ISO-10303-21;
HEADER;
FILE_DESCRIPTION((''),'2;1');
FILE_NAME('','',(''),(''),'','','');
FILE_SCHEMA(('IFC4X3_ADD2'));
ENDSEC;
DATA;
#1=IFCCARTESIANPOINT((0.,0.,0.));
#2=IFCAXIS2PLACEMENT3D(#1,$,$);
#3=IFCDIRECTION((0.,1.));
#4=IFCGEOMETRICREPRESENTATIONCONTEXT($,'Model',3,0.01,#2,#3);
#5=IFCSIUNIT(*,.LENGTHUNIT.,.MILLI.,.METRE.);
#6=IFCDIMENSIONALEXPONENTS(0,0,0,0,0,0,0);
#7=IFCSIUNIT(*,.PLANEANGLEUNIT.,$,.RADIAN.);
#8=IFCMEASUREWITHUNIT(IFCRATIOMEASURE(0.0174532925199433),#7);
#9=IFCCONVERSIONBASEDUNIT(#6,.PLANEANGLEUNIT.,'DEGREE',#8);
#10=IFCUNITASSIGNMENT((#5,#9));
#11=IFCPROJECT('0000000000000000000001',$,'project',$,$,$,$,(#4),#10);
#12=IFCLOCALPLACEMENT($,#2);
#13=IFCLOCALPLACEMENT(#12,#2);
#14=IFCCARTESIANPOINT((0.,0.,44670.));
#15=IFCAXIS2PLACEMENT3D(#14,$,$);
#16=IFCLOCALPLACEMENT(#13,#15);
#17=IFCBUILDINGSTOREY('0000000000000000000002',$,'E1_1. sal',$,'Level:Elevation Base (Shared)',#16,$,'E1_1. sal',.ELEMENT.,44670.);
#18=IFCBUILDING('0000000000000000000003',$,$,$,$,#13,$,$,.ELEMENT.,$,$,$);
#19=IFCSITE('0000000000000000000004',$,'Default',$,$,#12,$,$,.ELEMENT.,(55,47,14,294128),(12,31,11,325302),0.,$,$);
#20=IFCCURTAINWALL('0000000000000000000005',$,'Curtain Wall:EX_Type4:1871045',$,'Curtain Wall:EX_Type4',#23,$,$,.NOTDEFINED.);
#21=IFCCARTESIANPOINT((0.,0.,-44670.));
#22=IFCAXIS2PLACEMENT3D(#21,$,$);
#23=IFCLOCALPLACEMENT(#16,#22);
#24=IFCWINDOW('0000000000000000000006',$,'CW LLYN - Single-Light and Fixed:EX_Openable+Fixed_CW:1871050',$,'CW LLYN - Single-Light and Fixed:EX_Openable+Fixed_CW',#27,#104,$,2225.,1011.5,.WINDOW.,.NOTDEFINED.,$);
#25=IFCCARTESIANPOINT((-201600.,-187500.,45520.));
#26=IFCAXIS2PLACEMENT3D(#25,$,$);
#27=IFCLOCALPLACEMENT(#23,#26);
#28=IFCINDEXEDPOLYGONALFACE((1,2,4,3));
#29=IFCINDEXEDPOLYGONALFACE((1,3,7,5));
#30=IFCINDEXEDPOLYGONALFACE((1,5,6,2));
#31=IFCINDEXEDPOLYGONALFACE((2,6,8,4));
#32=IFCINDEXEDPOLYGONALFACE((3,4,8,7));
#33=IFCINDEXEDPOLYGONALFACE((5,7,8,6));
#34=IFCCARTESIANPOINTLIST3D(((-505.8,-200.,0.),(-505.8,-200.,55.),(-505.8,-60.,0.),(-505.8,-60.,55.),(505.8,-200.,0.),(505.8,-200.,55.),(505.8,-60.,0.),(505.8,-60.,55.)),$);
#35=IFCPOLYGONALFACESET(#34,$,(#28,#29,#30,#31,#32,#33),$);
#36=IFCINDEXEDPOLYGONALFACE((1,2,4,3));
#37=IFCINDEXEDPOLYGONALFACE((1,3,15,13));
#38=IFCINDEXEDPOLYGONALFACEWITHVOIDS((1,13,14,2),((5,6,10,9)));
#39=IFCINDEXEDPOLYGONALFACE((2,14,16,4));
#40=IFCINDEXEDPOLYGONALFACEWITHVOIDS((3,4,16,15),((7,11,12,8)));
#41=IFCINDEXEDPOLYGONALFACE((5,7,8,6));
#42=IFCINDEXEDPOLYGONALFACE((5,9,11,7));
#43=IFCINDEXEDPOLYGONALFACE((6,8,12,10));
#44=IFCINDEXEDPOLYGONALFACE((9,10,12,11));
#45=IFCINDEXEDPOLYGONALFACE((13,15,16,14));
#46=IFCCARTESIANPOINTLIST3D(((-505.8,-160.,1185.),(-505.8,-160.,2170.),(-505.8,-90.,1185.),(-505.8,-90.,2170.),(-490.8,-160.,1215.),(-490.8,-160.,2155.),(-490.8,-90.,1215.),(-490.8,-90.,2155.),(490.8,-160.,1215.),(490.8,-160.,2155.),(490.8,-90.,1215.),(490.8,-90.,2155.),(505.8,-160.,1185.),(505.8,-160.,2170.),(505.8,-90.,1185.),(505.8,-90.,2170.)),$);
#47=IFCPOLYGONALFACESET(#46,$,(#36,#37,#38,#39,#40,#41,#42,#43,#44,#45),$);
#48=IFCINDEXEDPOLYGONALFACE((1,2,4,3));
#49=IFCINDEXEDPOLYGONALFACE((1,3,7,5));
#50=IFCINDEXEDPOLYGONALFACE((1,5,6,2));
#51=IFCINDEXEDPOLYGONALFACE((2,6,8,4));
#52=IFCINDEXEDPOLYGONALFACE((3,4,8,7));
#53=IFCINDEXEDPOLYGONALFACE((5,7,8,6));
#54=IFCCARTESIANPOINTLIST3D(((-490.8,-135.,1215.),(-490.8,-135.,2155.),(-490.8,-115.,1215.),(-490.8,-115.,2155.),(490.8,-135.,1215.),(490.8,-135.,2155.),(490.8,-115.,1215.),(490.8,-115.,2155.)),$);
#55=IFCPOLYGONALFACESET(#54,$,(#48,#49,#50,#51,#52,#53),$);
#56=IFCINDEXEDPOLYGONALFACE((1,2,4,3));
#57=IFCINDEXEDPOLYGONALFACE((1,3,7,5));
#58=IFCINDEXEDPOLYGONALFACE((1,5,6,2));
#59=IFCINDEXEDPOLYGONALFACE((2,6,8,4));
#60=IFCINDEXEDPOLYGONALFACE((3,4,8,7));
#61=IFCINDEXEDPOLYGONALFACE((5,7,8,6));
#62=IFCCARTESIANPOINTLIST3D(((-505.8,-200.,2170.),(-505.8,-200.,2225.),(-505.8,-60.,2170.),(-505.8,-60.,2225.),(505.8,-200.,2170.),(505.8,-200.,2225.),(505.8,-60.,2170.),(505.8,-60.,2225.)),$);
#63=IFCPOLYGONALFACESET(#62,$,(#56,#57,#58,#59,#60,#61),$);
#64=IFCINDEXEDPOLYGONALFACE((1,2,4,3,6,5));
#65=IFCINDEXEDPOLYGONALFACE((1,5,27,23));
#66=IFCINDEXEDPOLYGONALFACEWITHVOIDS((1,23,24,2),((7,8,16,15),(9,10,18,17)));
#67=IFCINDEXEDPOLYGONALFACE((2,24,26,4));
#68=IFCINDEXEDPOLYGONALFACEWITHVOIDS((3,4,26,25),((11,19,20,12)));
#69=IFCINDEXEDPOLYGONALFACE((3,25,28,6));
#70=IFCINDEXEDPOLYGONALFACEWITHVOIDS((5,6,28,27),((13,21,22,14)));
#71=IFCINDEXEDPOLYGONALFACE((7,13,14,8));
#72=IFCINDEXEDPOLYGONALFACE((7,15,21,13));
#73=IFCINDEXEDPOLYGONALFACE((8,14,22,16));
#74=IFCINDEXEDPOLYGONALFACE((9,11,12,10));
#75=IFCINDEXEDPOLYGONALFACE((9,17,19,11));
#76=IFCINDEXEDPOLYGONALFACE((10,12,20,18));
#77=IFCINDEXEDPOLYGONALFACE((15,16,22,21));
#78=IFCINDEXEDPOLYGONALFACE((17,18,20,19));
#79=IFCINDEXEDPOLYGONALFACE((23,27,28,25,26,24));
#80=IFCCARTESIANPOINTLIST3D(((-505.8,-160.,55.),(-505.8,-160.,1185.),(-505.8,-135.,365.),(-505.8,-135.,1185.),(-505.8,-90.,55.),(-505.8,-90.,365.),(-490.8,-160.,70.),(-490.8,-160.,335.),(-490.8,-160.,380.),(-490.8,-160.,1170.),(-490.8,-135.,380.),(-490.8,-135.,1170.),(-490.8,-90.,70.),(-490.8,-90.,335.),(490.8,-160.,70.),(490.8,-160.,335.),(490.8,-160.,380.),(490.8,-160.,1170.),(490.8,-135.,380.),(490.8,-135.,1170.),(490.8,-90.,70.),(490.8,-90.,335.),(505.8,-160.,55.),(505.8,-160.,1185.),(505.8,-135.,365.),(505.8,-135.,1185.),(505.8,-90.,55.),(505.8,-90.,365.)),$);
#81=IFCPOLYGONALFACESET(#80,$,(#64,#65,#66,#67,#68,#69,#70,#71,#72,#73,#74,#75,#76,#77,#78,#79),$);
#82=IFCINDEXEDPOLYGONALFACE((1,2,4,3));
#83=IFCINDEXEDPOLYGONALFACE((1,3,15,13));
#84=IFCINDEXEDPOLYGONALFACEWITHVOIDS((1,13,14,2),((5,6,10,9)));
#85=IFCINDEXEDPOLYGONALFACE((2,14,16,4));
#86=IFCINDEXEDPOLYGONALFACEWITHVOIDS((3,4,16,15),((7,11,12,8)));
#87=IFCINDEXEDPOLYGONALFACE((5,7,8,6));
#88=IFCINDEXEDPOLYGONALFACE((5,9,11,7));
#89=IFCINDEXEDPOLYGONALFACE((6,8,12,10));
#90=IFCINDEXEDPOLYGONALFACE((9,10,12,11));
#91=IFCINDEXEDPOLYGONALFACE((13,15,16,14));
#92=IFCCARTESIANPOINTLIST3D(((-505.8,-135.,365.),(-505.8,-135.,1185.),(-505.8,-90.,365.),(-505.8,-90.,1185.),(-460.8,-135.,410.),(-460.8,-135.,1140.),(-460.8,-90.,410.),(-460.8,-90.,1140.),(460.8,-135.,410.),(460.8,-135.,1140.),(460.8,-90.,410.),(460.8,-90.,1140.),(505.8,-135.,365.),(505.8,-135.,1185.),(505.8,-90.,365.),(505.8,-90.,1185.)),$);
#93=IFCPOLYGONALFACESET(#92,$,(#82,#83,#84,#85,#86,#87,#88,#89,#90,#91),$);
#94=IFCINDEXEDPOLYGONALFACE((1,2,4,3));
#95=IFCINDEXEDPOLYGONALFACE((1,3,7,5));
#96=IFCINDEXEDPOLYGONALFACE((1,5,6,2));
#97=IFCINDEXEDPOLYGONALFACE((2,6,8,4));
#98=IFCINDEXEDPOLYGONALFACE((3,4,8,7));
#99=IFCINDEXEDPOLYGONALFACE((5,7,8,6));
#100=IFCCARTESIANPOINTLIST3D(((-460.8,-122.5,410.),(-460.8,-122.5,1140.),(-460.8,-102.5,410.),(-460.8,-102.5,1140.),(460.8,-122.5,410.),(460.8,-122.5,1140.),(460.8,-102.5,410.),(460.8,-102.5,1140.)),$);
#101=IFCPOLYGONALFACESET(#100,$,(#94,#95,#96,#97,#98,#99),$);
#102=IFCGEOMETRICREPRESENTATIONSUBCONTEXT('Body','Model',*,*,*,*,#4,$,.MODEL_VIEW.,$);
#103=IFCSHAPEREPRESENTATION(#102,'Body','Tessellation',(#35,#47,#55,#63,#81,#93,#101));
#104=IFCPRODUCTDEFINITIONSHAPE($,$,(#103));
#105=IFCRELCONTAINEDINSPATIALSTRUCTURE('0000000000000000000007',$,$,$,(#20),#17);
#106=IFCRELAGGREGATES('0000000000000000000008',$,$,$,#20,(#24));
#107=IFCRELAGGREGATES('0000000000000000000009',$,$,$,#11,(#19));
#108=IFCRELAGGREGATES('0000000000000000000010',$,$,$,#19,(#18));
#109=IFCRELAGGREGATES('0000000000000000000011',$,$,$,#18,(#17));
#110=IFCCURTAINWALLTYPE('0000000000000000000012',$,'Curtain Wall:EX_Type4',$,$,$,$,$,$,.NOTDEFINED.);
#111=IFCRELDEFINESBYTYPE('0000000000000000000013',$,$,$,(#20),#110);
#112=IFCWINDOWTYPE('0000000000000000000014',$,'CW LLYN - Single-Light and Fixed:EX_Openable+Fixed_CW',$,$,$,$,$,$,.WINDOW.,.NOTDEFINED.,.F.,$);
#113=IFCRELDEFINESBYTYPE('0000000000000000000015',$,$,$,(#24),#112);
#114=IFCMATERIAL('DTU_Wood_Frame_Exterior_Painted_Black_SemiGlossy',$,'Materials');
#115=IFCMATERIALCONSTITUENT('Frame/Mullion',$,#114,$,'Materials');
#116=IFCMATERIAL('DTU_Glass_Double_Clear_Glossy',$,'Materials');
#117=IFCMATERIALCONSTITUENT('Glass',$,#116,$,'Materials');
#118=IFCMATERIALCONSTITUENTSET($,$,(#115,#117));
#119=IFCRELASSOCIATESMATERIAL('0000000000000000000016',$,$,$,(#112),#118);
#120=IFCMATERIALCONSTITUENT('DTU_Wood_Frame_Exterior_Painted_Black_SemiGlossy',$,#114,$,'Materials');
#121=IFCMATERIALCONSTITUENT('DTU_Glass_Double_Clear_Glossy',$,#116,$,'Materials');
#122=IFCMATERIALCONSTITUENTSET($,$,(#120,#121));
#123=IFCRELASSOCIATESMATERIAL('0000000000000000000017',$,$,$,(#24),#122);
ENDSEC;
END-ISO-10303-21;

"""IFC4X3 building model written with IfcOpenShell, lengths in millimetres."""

from ifc_helpers import new_model, entity, si_unit, converted_unit, direction, frame, frame_2d, origin, origin_2d_with_axis, place, context, subcontext, project, spatial, polyline, rectangle, outline, extrude, source, transform, mapped, material, constituent, constituent_set, type_object, type_shapes, element, aggregate, save


model = new_model("IFC4X3")

# Units and contexts
model_context = context("Model", 3, precision=0.01, world=origin(), true_north=direction((0.0, 1.0)))
body_context = subcontext(model_context, "Body", "Model", "MODEL_VIEW")
ifc_project = project(units=[si_unit("LENGTHUNIT", "METRE", prefix="MILLI"), converted_unit("PLANEANGLEUNIT", "DEGREE", entity("IfcRatioMeasure", 0.0174532925199433), si_unit("PLANEANGLEUNIT", "RADIAN"), dimensions=[0, 0, 0, 0, 0, 0, 0])], contexts=[model_context])

# Site, building, storey
site_placement = place(None, origin())
site = spatial("IfcSite", under=ifc_project, at=site_placement, Name="Default", CompositionType="ELEMENT", RefLatitude=(55, 47, 14, 294128), RefLongitude=(12, 31, 11, 325302), RefElevation=0.0)
building_placement = place(site_placement, origin())
building = spatial("IfcBuilding", under=site, at=building_placement, CompositionType="ELEMENT")
storey_placement = place(building_placement, frame((0.0, 0.0, 44670.0)))
storey = spatial("IfcBuildingStorey", under=building, at=storey_placement, Name="E1_1. sal", ObjectType="Level:Elevation Base (Shared)", LongName="E1_1. sal", CompositionType="ELEMENT", Elevation=44670.0)

# Curtain wall
curtain_wall_type_1 = type_object("IfcCurtainWallType", Name="Curtain Wall:EX_Type4", PredefinedType="NOTDEFINED")
curtain_wall_1_placement = place(storey_placement, frame((0.0, 0.0, -44670.0)))
curtain_wall_1 = element("IfcCurtainWall", 1, at=curtain_wall_1_placement, inside=storey, type_object=curtain_wall_type_1, Name="Curtain Wall:EX_Type4:1871045", ObjectType="Curtain Wall:EX_Type4", PredefinedType="NOTDEFINED")

# Shared definitions
ifc_material_1 = material(Name="DTU_Wood_Frame_Exterior_Painted_Black_SemiGlossy", Category="Materials")
ifc_material_2 = material(Name="DTU_Glass_Double_Clear_Glossy", Category="Materials")

# Window, openings
ifc_constituent_1 = constituent(ifc_material_1, Name="DTU_Wood_Frame_Exterior_Painted_Black_SemiGlossy", Category="Materials")
ifc_constituent_2 = constituent(ifc_material_2, Name="DTU_Glass_Double_Clear_Glossy", Category="Materials")
ifc_constituent_set_1 = constituent_set(constituents=[ifc_constituent_1, ifc_constituent_2])
ifc_constituent_3 = constituent(ifc_material_1, Name="Frame/Mullion", Category="Materials")
ifc_constituent_4 = constituent(ifc_material_2, Name="Glass", Category="Materials")
ifc_constituent_set_2 = constituent_set(constituents=[ifc_constituent_3, ifc_constituent_4])
window_type_1 = type_object("IfcWindowType", Name="CW LLYN - Single-Light and Fixed:EX_Openable+Fixed_CW", ParameterTakesPrecedence=False, PartitioningType="NOTDEFINED", PredefinedType="WINDOW", material=ifc_constituent_set_2)
shared_shape_1 = source(origin(), body_context, "Body", "SweptSolid", [
    extrude(rectangle(XDim=140.0, YDim=1011.5, at=origin_2d_with_axis()), frame((0.0, -130.0, 0.0), z_axis=(0.0, 0.0, 1.0), x_axis=(0.0, -1.0, 0.0)), (0.0, 0.0, 1.0), 55.0),
    extrude(outline(polyline([(-492.5, -505.8), (492.5, -505.8), (492.5, 505.8), (-492.5, 505.8), (-492.5, -505.8)]), holes=[polyline([(477.5, -490.8), (-462.5, -490.8), (-462.5, 490.8), (477.5, 490.8), (477.5, -490.8)])]), frame((0.0, -90.0, 1677.5), z_axis=(0.0, -1.0, 0.0), x_axis=(0.0, 0.0, 1.0)), (0.0, 0.0, 1.0), 70.0),
    extrude(rectangle(XDim=981.5, YDim=20.0, at=frame_2d((0.0, 0.0), x_axis=(1.0, 0.0))), frame((0.0, -125.0, 1215.0), z_axis=(0.0, 0.0, 1.0), x_axis=(-1.0, 0.0, 0.0)), (0.0, 0.0, 1.0), 940.0),
    extrude(rectangle(XDim=981.5, YDim=20.0, at=origin_2d_with_axis()), frame((0.0, -125.0, 70.0), z_axis=(0.0, 0.0, 1.0), x_axis=(-1.0, 0.0, 0.0)), (0.0, 0.0, 1.0), 265.0),
    extrude(rectangle(XDim=140.0, YDim=1011.5, at=frame_2d((0.0, 0.0), x_axis=(1.0, 0.0))), frame((0.0, -130.0, 2170.0), z_axis=(0.0, 0.0, 1.0), x_axis=(0.0, -1.0, 0.0)), (0.0, 0.0, 1.0), 55.0),
    extrude(outline(polyline([(-38.3, -480.0), (31.7, -480.0), (31.7, 650.0), (6.7, 650.0), (6.7, -170.0), (-38.3, -170.0), (-38.3, -480.0)])), frame((505.8, -128.3, 535.0), z_axis=(-1.0, 0.0, 0.0), x_axis=(0.0, -1.0, 0.0)), (0.0, 0.0, 1.0), 1011.5),
    extrude(outline(polyline([(-410.0, -505.8), (410.0, -505.8), (410.0, 505.8), (-410.0, 505.8), (-410.0, -505.8)]), holes=[polyline([(-365.0, 460.8), (365.0, 460.8), (365.0, -460.8), (-365.0, -460.8), (-365.0, 460.8)])]), frame((0.0, -90.0, 775.0), z_axis=(0.0, -1.0, 0.0), x_axis=(0.0, 0.0, 1.0)), (0.0, 0.0, 1.0), 45.0),
    extrude(rectangle(XDim=921.5, YDim=20.0, at=frame_2d((0.0, 0.0), x_axis=(1.0, 0.0))), frame((0.0, -112.5, 410.0), z_axis=(0.0, 0.0, 1.0), x_axis=(-1.0, 0.0, 0.0)), (0.0, 0.0, 1.0), 730.0),
])
type_shapes(window_type_1, [shared_shape_1])
window_1_placement = place(curtain_wall_1_placement, frame((-201600.0, -187500.0, 45520.0)))
window_1 = element("IfcWindow", 2, at=window_1_placement, type_object=window_type_1, material=ifc_constituent_set_1, Name="CW LLYN - Single-Light and Fixed:EX_Openable+Fixed_CW:1871050", ObjectType="CW LLYN - Single-Light and Fixed:EX_Openable+Fixed_CW", OverallHeight=2225.0, OverallWidth=1011.5, PartitioningType="NOTDEFINED", PredefinedType="WINDOW", context=body_context, shape_type="MappedRepresentation", body=[
    mapped(shared_shape_1, transform((0.0, 0.0, 0.0), scale=1.0)),
])
opening_1_placement = place(curtain_wall_1_placement, frame((-201600.0, -187500.0, 90190.0), z_axis=(0.0, 0.0, 1.0), x_axis=(-1.0, 0.0, 0.0)))
opening_1 = element("IfcOpeningElement", 3, at=opening_1_placement, cuts=window_1, PredefinedType="OPENING", context=body_context, shape_type="SweptSolid", body=[
    extrude(rectangle(XDim=265.0, YDim=981.5, at=frame_2d((0.0, 0.0), x_axis=(1.0, 0.0))), frame((0.0, 160.0, -44467.5), z_axis=(0.0, -1.0, 0.0), x_axis=(0.0, 0.0, 1.0)), (0.0, 0.0, 1.0), 70.0),
])
opening_2_placement = place(curtain_wall_1_placement, frame((-201600.0, -187500.0, 90190.0), z_axis=(0.0, 0.0, 1.0), x_axis=(-1.0, 0.0, 0.0)))
opening_2 = element("IfcOpeningElement", 4, at=opening_2_placement, cuts=window_1, PredefinedType="OPENING", context=body_context, shape_type="SweptSolid", body=[
    extrude(rectangle(XDim=790.0, YDim=981.5, at=frame_2d((0.0, 0.0), x_axis=(1.0, 0.0))), frame((0.0, 135.0, -43895.0), z_axis=(0.0, 1.0, 0.0), x_axis=(0.0, 0.0, 1.0)), (0.0, 0.0, 1.0), 25.0),
])
aggregate(curtain_wall_1, [window_1, opening_1, opening_2])

save(model, "model.ifc")
